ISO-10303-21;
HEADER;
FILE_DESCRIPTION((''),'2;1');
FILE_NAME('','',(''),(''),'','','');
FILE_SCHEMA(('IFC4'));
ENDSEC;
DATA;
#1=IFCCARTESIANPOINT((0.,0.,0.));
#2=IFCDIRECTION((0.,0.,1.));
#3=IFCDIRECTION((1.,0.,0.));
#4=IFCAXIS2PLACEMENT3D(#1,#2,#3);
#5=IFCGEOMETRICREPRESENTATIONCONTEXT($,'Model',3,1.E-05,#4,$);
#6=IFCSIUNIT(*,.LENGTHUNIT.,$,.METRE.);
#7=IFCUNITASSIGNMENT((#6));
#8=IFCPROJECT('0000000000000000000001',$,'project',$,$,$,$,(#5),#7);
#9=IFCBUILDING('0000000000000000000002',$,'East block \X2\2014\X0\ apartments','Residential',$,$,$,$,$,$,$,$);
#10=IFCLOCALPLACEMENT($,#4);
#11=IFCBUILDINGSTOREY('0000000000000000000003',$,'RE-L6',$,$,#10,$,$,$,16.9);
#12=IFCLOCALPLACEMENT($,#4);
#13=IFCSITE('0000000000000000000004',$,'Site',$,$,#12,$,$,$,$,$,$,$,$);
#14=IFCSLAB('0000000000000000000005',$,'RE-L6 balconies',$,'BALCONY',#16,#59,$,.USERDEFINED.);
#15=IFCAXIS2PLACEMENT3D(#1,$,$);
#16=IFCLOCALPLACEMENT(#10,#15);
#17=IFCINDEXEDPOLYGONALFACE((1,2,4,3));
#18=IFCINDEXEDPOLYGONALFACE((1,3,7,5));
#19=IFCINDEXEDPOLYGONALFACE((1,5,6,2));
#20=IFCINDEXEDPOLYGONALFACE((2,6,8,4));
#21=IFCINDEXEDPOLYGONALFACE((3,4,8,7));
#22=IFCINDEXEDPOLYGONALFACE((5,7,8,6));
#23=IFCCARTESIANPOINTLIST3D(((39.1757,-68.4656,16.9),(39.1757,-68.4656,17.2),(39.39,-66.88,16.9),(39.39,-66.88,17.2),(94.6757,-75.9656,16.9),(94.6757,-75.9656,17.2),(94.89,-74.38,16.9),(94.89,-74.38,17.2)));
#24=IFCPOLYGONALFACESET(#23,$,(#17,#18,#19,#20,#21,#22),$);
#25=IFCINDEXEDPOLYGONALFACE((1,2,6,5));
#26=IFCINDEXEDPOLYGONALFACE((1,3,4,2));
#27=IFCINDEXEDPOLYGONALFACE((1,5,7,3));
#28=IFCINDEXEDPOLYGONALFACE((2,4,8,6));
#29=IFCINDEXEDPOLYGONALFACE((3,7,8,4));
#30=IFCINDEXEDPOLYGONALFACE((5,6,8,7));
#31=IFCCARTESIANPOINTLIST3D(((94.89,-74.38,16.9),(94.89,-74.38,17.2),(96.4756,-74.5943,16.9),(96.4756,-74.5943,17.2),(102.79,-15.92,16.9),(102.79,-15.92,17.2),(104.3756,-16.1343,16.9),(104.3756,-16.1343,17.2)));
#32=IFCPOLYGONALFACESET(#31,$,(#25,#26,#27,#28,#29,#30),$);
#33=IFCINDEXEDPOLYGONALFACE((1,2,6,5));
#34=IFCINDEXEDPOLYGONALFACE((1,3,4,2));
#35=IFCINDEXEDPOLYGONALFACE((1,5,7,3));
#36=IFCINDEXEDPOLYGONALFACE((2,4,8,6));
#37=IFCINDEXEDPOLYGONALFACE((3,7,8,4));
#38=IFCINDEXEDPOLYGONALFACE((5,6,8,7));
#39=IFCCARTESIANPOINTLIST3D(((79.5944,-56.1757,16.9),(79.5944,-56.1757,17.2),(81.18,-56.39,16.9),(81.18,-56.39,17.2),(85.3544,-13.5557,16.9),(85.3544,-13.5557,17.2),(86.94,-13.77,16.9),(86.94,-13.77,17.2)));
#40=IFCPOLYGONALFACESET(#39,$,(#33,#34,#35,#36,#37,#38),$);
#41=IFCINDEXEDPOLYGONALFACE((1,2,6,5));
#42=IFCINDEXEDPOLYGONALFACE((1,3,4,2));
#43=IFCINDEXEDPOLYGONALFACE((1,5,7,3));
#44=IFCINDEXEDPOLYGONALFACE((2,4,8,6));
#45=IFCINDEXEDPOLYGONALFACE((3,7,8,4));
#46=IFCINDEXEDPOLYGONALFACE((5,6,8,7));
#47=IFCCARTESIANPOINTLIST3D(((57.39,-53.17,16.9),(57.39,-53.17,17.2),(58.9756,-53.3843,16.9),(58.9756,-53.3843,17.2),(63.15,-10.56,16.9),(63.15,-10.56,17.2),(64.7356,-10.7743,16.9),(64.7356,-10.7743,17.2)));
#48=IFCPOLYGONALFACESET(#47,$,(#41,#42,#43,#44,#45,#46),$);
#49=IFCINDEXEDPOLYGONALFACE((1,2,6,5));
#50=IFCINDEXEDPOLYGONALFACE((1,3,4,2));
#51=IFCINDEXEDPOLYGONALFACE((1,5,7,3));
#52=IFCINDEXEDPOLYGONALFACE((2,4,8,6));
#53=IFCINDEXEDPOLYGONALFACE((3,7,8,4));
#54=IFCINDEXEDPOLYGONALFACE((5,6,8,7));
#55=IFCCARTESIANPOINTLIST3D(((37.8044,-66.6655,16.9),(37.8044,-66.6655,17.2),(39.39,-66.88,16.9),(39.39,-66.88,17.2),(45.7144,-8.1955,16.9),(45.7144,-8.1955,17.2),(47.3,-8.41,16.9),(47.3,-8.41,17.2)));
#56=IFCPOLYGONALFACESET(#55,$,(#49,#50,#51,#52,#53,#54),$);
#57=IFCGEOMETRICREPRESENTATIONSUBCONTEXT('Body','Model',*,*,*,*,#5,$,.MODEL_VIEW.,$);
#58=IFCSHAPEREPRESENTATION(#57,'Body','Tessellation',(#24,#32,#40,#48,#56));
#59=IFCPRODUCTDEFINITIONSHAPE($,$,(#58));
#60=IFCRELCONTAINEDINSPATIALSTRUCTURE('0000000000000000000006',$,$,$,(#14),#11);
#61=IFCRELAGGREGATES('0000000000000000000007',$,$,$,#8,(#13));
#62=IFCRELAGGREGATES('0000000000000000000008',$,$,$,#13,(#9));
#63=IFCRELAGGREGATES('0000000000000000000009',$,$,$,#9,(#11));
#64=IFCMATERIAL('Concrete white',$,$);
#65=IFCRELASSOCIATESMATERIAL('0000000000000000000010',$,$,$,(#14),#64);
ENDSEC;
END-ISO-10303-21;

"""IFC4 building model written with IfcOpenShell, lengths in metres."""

from ifc_helpers import new_model, si_unit, frame, origin_with_axes, place, context, subcontext, project, spatial, polyline, outline, extrude, material, element, save


model = new_model("IFC4")

# Units and contexts
model_context = context("Model", 3, precision=1e-05, world=origin_with_axes())
body_context = subcontext(model_context, "Body", "Model", "MODEL_VIEW")
ifc_project = project(units=[si_unit("LENGTHUNIT", "METRE")], contexts=[model_context])

# Site, building, storey
site_placement = place(None, origin_with_axes())
site = spatial("IfcSite", under=ifc_project, at=site_placement, Name="Site")
building = spatial("IfcBuilding", under=site, Name="East block — apartments", Description="Residential")
storey_placement = place(None, origin_with_axes())
storey = spatial("IfcBuildingStorey", under=building, at=storey_placement, Name="RE-L6", Elevation=16.9)

# Slab
ifc_material_1 = material(Name="Concrete white")
slab_placement = place(storey_placement, origin_with_axes())
element("IfcSlab", 1, at=slab_placement, inside=storey, material=ifc_material_1, Name="RE-L6 balconies", ObjectType="BALCONY", PredefinedType="USERDEFINED", context=body_context, shape_type="SweptSolid", body=[
    extrude(outline(polyline([(39.39, -66.88), (94.89, -74.38), (94.6757, -75.9656), (39.1757, -68.4656), (39.39, -66.88)])), frame((0.0, 0.0, 16.9), z_axis=(0.0, 0.0, 1.0), x_axis=(1.0, 0.0, 0.0)), (0.0, 0.0, 1.0), 0.3),
    extrude(outline(polyline([(94.89, -74.38), (102.79, -15.92), (104.3756, -16.1343), (96.4756, -74.5943), (94.89, -74.38)])), frame((0.0, 0.0, 16.9), z_axis=(0.0, 0.0, 1.0), x_axis=(1.0, 0.0, 0.0)), (0.0, 0.0, 1.0), 0.3),
    extrude(outline(polyline([(86.94, -13.77), (81.18, -56.39), (79.5944, -56.1757), (85.3544, -13.5557), (86.94, -13.77)])), frame((0.0, 0.0, 16.9), z_axis=(0.0, 0.0, 1.0), x_axis=(1.0, 0.0, 0.0)), (0.0, 0.0, 1.0), 0.3),
    extrude(outline(polyline([(57.39, -53.17), (63.15, -10.56), (64.7356, -10.7743), (58.9756, -53.3843), (57.39, -53.17)])), frame((0.0, 0.0, 16.9), z_axis=(0.0, 0.0, 1.0), x_axis=(1.0, 0.0, 0.0)), (0.0, 0.0, 1.0), 0.3),
    extrude(outline(polyline([(47.3, -8.41), (39.39, -66.88), (37.8044, -66.6655), (45.7144, -8.1955), (47.3, -8.41)])), frame((0.0, 0.0, 16.9), z_axis=(0.0, 0.0, 1.0), x_axis=(1.0, 0.0, 0.0)), (0.0, 0.0, 1.0), 0.3),
])

save(model, "model.ifc")
